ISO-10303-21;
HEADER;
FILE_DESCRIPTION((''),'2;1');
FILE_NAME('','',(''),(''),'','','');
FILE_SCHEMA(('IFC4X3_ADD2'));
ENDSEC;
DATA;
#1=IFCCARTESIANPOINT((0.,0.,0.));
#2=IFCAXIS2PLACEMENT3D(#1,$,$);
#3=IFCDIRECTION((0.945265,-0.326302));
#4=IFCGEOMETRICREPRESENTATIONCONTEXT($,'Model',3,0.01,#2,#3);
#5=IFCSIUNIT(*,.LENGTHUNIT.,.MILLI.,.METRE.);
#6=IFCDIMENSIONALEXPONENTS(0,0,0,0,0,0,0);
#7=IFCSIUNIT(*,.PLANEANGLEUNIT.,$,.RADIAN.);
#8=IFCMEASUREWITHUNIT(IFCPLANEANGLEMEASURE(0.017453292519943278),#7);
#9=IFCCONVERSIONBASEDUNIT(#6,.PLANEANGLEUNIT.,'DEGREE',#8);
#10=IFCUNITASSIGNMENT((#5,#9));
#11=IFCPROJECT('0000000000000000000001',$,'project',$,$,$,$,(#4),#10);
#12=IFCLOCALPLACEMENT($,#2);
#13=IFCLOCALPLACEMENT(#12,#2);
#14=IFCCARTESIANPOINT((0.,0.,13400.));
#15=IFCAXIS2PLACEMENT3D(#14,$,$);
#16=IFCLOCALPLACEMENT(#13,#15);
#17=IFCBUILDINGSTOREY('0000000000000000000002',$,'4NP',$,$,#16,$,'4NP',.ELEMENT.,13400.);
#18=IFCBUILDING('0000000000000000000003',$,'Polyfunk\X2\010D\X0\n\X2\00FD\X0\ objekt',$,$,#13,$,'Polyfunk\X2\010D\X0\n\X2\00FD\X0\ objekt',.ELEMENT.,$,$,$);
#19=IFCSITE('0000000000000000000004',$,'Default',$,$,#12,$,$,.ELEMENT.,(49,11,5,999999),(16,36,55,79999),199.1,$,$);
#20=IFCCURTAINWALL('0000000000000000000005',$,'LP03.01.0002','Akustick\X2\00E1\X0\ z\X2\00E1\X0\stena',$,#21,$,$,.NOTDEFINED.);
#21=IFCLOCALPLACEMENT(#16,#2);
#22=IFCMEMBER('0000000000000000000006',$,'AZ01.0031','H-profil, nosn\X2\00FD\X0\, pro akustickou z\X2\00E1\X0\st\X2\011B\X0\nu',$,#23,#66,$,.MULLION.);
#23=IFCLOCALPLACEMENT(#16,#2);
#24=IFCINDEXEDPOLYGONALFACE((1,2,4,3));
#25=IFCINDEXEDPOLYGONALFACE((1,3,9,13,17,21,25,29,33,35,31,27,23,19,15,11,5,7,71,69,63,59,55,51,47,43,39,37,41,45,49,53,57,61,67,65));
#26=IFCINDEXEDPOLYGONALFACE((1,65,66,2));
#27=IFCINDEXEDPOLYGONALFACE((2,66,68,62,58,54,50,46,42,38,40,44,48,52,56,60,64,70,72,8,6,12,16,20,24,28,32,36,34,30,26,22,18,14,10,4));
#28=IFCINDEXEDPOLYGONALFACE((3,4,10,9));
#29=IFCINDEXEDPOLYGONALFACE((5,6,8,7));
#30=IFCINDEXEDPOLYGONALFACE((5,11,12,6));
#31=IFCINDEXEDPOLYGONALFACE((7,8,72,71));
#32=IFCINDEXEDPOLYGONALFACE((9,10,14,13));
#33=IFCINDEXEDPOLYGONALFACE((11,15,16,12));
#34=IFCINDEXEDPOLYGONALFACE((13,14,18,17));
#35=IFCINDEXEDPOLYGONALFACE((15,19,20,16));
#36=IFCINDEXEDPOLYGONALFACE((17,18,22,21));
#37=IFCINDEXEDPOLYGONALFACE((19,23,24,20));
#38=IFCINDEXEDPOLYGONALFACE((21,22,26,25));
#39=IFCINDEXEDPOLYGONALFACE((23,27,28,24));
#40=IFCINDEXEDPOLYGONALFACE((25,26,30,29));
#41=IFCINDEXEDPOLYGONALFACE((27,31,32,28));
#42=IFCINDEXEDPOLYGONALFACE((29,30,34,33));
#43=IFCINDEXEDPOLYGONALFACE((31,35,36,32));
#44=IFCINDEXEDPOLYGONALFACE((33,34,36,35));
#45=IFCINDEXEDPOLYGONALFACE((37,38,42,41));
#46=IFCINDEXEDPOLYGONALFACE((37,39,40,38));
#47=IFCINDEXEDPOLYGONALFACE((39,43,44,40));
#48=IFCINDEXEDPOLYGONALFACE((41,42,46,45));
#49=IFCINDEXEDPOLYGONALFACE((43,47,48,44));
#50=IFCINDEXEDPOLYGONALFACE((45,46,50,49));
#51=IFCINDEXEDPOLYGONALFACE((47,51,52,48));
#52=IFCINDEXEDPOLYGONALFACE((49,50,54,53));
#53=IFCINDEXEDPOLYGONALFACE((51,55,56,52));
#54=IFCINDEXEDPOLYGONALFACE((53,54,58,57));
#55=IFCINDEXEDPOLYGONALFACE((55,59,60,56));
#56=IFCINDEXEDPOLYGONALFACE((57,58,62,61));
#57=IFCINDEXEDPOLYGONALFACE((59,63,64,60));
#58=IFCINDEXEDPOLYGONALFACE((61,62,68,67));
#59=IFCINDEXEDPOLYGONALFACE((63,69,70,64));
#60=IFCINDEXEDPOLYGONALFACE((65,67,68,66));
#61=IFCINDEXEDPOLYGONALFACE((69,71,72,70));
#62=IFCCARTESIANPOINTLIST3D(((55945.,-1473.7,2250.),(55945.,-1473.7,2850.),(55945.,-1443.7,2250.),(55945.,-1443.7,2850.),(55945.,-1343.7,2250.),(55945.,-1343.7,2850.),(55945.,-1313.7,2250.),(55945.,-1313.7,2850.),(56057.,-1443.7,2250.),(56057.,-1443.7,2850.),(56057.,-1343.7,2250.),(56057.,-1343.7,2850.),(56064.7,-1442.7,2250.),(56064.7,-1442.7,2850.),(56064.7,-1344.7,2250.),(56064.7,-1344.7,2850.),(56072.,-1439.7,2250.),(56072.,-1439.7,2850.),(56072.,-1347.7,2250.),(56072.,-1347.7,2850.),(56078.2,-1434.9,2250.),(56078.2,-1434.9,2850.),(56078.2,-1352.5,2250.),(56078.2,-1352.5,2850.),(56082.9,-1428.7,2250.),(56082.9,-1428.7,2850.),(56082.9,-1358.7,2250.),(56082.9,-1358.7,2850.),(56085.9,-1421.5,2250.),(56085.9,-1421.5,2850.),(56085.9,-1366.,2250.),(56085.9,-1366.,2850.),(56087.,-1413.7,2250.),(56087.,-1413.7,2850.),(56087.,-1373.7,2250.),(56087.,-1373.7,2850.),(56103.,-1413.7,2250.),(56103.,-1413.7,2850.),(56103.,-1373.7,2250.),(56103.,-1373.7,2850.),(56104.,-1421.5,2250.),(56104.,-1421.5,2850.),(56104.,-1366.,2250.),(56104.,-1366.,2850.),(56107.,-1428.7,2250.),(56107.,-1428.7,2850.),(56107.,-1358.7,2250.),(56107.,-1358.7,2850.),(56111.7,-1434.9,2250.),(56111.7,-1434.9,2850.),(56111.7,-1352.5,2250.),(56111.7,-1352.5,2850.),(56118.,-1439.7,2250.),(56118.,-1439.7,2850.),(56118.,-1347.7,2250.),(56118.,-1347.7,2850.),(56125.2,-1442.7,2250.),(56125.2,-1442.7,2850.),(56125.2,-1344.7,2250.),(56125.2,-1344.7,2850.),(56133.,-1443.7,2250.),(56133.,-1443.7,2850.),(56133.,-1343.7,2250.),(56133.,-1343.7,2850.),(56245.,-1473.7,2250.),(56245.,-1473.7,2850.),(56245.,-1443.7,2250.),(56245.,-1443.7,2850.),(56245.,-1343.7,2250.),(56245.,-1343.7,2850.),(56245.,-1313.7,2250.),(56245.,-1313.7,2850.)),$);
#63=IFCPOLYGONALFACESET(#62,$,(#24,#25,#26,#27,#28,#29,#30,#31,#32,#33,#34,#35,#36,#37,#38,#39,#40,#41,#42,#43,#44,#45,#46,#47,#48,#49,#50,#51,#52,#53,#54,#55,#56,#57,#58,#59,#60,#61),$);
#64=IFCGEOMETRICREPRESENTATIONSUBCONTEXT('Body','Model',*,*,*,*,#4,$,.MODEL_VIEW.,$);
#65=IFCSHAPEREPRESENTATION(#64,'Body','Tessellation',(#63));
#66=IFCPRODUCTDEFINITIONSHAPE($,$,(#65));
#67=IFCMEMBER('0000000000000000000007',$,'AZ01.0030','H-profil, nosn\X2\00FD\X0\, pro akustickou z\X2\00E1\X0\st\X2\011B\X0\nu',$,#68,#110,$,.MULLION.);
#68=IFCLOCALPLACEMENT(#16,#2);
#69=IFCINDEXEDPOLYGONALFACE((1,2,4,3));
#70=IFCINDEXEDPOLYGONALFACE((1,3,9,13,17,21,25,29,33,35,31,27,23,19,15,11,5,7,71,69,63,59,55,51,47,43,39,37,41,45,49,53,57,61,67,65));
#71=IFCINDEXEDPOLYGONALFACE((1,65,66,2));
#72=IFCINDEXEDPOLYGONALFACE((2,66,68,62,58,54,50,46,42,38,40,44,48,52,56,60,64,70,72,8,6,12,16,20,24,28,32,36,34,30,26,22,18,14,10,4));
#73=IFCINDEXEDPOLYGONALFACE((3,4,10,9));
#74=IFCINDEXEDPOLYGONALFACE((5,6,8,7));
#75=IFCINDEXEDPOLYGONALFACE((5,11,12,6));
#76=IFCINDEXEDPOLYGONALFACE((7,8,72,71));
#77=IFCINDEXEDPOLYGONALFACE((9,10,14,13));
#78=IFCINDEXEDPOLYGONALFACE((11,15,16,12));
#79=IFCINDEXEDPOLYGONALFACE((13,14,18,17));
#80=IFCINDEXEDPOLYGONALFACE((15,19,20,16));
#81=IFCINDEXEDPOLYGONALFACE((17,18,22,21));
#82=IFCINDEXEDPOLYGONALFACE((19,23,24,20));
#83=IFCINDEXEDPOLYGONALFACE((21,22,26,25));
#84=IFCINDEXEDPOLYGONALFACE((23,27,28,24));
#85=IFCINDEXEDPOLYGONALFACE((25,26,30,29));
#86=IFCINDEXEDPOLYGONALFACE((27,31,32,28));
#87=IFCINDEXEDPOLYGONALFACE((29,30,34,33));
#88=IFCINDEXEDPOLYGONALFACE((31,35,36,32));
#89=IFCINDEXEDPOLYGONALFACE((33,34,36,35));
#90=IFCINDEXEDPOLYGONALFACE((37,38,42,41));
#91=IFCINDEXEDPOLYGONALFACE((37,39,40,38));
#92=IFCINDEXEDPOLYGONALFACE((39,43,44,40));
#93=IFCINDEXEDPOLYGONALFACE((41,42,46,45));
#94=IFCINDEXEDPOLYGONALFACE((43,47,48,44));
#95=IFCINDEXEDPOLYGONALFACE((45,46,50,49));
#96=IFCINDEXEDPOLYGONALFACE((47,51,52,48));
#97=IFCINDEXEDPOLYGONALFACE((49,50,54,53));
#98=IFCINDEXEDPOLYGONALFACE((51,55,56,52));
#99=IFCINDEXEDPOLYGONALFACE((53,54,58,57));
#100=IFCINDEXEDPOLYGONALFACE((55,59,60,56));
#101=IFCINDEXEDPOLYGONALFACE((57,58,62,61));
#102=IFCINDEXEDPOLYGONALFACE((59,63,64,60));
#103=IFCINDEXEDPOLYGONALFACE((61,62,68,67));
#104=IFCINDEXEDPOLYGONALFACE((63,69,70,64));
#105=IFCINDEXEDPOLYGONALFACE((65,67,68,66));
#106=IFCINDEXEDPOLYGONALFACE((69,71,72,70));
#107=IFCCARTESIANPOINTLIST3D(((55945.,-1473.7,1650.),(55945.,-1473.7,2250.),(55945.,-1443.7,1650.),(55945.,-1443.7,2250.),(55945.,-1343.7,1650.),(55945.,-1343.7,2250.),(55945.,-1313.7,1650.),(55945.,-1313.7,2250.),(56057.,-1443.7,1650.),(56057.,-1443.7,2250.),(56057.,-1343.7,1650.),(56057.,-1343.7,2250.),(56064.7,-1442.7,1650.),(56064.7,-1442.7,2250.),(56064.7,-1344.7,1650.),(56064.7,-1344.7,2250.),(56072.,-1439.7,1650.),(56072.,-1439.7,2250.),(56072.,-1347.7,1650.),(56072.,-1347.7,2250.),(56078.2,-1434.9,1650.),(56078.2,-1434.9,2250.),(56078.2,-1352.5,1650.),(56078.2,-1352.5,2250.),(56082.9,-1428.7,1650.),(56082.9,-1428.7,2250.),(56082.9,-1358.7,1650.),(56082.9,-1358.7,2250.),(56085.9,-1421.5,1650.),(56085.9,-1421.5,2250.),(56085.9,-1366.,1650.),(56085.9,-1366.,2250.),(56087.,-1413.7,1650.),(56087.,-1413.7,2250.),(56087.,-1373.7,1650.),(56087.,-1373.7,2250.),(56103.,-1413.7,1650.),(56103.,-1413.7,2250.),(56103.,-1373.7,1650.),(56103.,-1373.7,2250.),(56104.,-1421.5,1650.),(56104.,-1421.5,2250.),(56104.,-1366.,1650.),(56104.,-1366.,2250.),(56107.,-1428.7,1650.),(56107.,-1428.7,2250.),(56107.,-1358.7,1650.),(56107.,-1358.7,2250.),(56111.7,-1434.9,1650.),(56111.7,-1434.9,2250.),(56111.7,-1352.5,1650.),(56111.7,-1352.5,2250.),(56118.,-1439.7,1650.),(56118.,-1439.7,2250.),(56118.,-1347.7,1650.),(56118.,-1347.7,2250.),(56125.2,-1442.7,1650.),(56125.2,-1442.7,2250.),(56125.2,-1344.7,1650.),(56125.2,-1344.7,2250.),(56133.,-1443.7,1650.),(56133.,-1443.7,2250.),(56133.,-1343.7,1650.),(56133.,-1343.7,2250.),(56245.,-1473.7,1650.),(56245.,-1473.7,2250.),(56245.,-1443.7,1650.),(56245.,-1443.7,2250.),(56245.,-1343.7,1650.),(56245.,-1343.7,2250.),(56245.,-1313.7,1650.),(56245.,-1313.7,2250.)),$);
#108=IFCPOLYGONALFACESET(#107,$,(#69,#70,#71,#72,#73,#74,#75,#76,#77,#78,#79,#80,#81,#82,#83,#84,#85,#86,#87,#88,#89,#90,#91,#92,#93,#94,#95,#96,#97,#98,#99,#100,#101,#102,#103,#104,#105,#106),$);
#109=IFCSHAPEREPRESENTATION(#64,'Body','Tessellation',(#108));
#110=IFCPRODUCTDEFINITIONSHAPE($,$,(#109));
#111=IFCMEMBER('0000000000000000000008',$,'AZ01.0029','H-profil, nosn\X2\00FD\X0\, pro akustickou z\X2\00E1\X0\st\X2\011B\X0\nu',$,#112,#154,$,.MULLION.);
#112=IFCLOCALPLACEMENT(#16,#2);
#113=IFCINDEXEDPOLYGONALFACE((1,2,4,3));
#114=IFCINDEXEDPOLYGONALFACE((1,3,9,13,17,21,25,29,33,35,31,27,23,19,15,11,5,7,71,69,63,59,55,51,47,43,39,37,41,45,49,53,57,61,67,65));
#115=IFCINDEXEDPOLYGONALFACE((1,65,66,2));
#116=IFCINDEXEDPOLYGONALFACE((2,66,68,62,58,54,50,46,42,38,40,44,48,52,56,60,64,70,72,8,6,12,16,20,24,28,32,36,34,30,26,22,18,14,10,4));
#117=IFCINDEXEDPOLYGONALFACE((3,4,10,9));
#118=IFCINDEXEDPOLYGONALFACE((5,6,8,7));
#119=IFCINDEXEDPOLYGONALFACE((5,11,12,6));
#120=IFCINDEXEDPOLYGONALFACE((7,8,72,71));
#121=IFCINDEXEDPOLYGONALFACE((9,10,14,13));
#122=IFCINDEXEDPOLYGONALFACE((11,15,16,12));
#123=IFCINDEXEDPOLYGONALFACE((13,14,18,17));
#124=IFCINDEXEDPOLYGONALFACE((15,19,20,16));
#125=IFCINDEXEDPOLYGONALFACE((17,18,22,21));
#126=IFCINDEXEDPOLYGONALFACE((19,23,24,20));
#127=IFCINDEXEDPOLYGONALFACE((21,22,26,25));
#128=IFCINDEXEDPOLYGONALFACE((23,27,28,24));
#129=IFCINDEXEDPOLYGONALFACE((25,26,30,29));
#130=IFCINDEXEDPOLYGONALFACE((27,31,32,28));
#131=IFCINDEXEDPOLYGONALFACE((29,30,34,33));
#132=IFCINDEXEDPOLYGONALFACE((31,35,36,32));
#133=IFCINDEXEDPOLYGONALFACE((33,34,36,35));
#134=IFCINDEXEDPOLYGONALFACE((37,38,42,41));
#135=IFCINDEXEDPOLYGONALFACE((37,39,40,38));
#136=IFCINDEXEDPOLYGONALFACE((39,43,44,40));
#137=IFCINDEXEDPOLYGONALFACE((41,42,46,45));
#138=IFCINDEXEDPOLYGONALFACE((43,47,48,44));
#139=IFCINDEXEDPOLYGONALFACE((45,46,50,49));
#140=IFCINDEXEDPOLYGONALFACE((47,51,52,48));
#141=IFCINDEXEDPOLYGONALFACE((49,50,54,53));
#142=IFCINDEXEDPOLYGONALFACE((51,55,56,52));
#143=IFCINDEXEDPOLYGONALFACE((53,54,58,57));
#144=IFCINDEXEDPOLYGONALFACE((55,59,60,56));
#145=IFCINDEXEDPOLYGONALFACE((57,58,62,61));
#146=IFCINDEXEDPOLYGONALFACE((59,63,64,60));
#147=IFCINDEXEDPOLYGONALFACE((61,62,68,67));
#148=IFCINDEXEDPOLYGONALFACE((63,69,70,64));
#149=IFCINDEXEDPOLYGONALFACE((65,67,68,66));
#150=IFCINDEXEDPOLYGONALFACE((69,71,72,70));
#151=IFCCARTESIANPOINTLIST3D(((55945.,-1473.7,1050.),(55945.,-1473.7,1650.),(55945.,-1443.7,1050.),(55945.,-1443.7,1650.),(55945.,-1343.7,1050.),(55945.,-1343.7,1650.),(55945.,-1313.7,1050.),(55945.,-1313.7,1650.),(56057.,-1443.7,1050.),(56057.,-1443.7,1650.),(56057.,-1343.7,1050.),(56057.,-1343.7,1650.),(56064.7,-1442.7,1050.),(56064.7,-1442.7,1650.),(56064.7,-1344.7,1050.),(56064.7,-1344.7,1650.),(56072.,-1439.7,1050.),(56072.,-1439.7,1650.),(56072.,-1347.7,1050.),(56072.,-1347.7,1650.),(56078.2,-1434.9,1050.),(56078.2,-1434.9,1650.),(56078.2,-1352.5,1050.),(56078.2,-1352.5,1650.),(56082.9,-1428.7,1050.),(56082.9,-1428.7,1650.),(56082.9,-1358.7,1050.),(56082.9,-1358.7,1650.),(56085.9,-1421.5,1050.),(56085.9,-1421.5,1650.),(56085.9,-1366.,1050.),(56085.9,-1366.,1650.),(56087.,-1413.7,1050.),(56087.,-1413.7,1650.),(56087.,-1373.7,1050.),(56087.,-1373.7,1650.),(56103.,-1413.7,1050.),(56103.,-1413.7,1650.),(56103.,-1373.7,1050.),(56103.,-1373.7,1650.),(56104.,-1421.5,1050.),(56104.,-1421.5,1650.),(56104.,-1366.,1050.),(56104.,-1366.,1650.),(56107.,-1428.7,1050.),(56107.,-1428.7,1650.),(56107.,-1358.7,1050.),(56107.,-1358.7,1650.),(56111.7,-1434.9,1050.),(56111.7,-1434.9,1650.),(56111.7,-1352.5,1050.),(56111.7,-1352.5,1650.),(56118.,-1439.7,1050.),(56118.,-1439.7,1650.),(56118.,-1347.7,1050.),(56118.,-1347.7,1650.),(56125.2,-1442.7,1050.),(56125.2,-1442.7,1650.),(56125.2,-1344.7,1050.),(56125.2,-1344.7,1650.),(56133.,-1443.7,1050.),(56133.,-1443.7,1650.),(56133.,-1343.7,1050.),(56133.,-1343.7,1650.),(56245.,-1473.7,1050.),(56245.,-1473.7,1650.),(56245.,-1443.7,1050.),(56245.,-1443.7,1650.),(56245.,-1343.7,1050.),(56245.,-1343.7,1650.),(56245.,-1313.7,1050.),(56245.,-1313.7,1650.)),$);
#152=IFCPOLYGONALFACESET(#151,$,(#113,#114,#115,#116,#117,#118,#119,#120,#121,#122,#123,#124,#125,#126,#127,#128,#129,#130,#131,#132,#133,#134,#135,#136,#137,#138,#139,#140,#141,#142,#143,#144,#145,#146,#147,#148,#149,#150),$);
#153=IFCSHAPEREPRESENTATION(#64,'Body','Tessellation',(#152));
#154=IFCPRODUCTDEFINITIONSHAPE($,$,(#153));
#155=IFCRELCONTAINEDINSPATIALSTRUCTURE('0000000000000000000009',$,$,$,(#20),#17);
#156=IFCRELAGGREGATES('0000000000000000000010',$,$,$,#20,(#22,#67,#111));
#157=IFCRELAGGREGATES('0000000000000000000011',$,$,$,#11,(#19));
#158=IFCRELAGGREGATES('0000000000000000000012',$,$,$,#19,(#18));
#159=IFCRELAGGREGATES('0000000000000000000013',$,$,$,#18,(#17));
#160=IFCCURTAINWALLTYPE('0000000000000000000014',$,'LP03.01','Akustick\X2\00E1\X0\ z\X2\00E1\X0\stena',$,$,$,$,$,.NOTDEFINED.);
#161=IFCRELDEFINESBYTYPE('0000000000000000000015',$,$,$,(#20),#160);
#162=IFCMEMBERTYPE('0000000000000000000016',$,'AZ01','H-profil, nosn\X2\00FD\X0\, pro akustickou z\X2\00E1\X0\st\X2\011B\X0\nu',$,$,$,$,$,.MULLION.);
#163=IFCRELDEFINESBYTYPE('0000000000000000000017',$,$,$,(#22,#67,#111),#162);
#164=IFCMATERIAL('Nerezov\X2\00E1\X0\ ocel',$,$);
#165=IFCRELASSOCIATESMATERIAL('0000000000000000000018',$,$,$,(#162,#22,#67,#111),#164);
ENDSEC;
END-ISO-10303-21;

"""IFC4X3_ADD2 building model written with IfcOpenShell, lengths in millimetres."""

from ifc_helpers import new_model, entity, si_unit, converted_unit, direction, frame, frame_2d, origin, place, context, subcontext, project, spatial, polyline, circle_curve, parameter, trimmed, segment, composite_curve, outline, extrude, source, transform, mapped, material, material_profile, profile_set, profile_usage, type_object, element, aggregate, save


model = new_model("IFC4X3_ADD2")

# Units and contexts
model_context = context("Model", 3, precision=0.01, world=origin(), true_north=direction((0.945265, -0.326302)))
body_context = subcontext(model_context, "Body", "Model", "MODEL_VIEW")
ifc_project = project(units=[si_unit("LENGTHUNIT", "METRE", prefix="MILLI"), converted_unit("PLANEANGLEUNIT", "DEGREE", entity("IfcPlaneAngleMeasure", 0.017453292519943278), si_unit("PLANEANGLEUNIT", "RADIAN"), dimensions=[0, 0, 0, 0, 0, 0, 0])], contexts=[model_context])

# Site, building, storey
site_placement = place(None, origin())
site = spatial("IfcSite", under=ifc_project, at=site_placement, Name="Default", CompositionType="ELEMENT", RefLatitude=(49, 11, 5, 999999), RefLongitude=(16, 36, 55, 79999), RefElevation=199.1)
building_placement = place(site_placement, origin())
building = spatial("IfcBuilding", under=site, at=building_placement, Name="Polyfunkčný objekt", LongName="Polyfunkčný objekt", CompositionType="ELEMENT")
storey_placement = place(building_placement, frame((0.0, 0.0, 13400.0)))
storey = spatial("IfcBuildingStorey", under=building, at=storey_placement, Name="4NP", LongName="4NP", CompositionType="ELEMENT", Elevation=13400.0)

# Curtain wall, members
curtain_wall_type_1 = type_object("IfcCurtainWallType", Name="LP03.01", Description="Akustická zástena", PredefinedType="NOTDEFINED")
curtain_wall_1_placement = place(storey_placement, frame((0.0, 0.0, -13400.0)))
curtain_wall_1 = element("IfcCurtainWall", 1, at=curtain_wall_1_placement, inside=storey, type_object=curtain_wall_type_1, Name="LP03.01.0002", Description="Akustická zástena", PredefinedType="NOTDEFINED")
ifc_material_1 = material(Name="Nerezová ocel")
ifc_material_profile = material_profile(ifc_material_1, outline(composite_curve([segment(polyline([(50.0, -150.0), (80.0, -150.0)]), True, "CONTINUOUS"), segment(polyline([(80.0, -150.0), (80.0, 150.0)]), True, "CONTINUOUS"), segment(polyline([(80.0, 150.0), (50.0, 150.0)]), True, "CONTINUOUS"), segment(polyline([(50.0, 150.0), (50.0, 38.0)]), True, "CONTINUOUS"), segment(trimmed(circle_curve(frame_2d((20.0, 38.0), x_axis=(0.0, 1.0)), 30.0), [parameter(180.0)], [parameter(270.0)], True, "PARAMETER"), False, "CONTINUOUS"), segment(polyline([(20.0, 8.0), (-20.0, 8.0)]), True, "CONTINUOUS"), segment(trimmed(circle_curve(frame_2d((-20.0, 38.0), x_axis=(0.0, 1.0)), 30.0), [parameter(90.0)], [parameter(180.0)], True, "PARAMETER"), False, "CONTINUOUS"), segment(polyline([(-50.0, 38.0), (-50.0, 150.0)]), True, "CONTINUOUS"), segment(polyline([(-50.0, 150.0), (-80.0, 150.0)]), True, "CONTINUOUS"), segment(polyline([(-80.0, 150.0), (-80.0, -150.0)]), True, "CONTINUOUS"), segment(polyline([(-80.0, -150.0), (-50.0, -150.0)]), True, "CONTINUOUS"), segment(polyline([(-50.0, -150.0), (-50.0, -38.0)]), True, "CONTINUOUS"), segment(trimmed(circle_curve(frame_2d((-20.0, -38.0), x_axis=(0.0, 1.0)), 30.0), [parameter(0.0)], [parameter(90.0)], True, "PARAMETER"), False, "CONTINUOUS"), segment(polyline([(-20.0, -8.0), (20.0, -8.0)]), True, "CONTINUOUS"), segment(trimmed(circle_curve(frame_2d((20.0, -38.0), x_axis=(0.0, 1.0)), 30.0), [parameter(270.0)], [parameter(0.0)], True, "PARAMETER"), False, "CONTINUOUS"), segment(polyline([(50.0, -38.0), (50.0, -150.0)]), True, "CONTINUOUS")], self_intersect=False)), Name="Profil zástena")
ifc_profile_set = profile_set([ifc_material_profile], Name="Profil zástena")
ifc_profile_usage = profile_usage(ifc_profile_set)
member_type = type_object("IfcMemberType", Name="AZ01", Description="H-profil, nosný, pro akustickou zástěnu", PredefinedType="MULLION", material=ifc_profile_set)
shared_shape_1 = source(origin(), body_context, "Body", "SweptSolid", [
    extrude(outline(composite_curve([segment(polyline([(50.0, -150.0), (80.0, -150.0)]), True, "CONTINUOUS"), segment(polyline([(80.0, -150.0), (80.0, 150.0)]), True, "CONTINUOUS"), segment(polyline([(80.0, 150.0), (50.0, 150.0)]), True, "CONTINUOUS"), segment(polyline([(50.0, 150.0), (50.0, 38.0)]), True, "CONTINUOUS"), segment(trimmed(circle_curve(frame_2d((20.0, 38.0), x_axis=(0.0, 1.0)), 30.0), [parameter(180.0)], [parameter(270.0)], True, "PARAMETER"), False, "CONTINUOUS"), segment(polyline([(20.0, 8.0), (-20.0, 8.0)]), True, "CONTINUOUS"), segment(trimmed(circle_curve(frame_2d((-20.0, 38.0), x_axis=(0.0, 1.0)), 30.0), [parameter(90.0)], [parameter(180.0)], True, "PARAMETER"), False, "CONTINUOUS"), segment(polyline([(-50.0, 38.0), (-50.0, 150.0)]), True, "CONTINUOUS"), segment(polyline([(-50.0, 150.0), (-80.0, 150.0)]), True, "CONTINUOUS"), segment(polyline([(-80.0, 150.0), (-80.0, -150.0)]), True, "CONTINUOUS"), segment(polyline([(-80.0, -150.0), (-50.0, -150.0)]), True, "CONTINUOUS"), segment(polyline([(-50.0, -150.0), (-50.0, -38.0)]), True, "CONTINUOUS"), segment(trimmed(circle_curve(frame_2d((-20.0, -38.0), x_axis=(0.0, 1.0)), 30.0), [parameter(0.0)], [parameter(90.0)], True, "PARAMETER"), False, "CONTINUOUS"), segment(polyline([(-20.0, -8.0), (20.0, -8.0)]), True, "CONTINUOUS"), segment(trimmed(circle_curve(frame_2d((20.0, -38.0), x_axis=(0.0, 1.0)), 30.0), [parameter(270.0)], [parameter(0.0)], True, "PARAMETER"), False, "CONTINUOUS"), segment(polyline([(50.0, -38.0), (50.0, -150.0)]), True, "CONTINUOUS")], self_intersect=False)), frame((-150.0, 0.0, -600.0), z_axis=(0.0, 0.0, 1.0), x_axis=(0.0, -1.0, 0.0)), (0.0, 0.0, 1.0), 600.0),
])
member_1_placement = place(curtain_wall_1_placement, frame((56245.0, -1393.7, 15650.0), z_axis=(0.0, 0.0, -1.0), x_axis=(1.0, 0.0, 0.0)))
member_1 = element("IfcMember", 2, at=member_1_placement, type_object=member_type, material=ifc_profile_usage, Name="AZ01.0031", Description="H-profil, nosný, pro akustickou zástěnu", PredefinedType="MULLION", context=body_context, shape_type="MappedRepresentation", body=[
    mapped(shared_shape_1, transform((0.0, 0.0, 0.0), scale=1.0)),
])
member_2_placement = place(curtain_wall_1_placement, frame((56245.0, -1393.7, 15050.0), z_axis=(0.0, 0.0, -1.0), x_axis=(1.0, 0.0, 0.0)))
member_2 = element("IfcMember", 3, at=member_2_placement, type_object=member_type, material=ifc_profile_usage, Name="AZ01.0030", Description="H-profil, nosný, pro akustickou zástěnu", PredefinedType="MULLION", context=body_context, shape_type="MappedRepresentation", body=[
    mapped(shared_shape_1, transform((0.0, 0.0, 0.0), scale=1.0)),
])
member_3_placement = place(curtain_wall_1_placement, frame((56245.0, -1393.7, 14450.0), z_axis=(0.0, 0.0, -1.0), x_axis=(1.0, 0.0, 0.0)))
member_3 = element("IfcMember", 4, at=member_3_placement, type_object=member_type, material=ifc_profile_usage, Name="AZ01.0029", Description="H-profil, nosný, pro akustickou zástěnu", PredefinedType="MULLION", context=body_context, shape_type="MappedRepresentation", body=[
    mapped(shared_shape_1, transform((0.0, 0.0, 0.0), scale=1.0)),
])
aggregate(curtain_wall_1, [member_1, member_2, member_3])

save(model, "model.ifc")
